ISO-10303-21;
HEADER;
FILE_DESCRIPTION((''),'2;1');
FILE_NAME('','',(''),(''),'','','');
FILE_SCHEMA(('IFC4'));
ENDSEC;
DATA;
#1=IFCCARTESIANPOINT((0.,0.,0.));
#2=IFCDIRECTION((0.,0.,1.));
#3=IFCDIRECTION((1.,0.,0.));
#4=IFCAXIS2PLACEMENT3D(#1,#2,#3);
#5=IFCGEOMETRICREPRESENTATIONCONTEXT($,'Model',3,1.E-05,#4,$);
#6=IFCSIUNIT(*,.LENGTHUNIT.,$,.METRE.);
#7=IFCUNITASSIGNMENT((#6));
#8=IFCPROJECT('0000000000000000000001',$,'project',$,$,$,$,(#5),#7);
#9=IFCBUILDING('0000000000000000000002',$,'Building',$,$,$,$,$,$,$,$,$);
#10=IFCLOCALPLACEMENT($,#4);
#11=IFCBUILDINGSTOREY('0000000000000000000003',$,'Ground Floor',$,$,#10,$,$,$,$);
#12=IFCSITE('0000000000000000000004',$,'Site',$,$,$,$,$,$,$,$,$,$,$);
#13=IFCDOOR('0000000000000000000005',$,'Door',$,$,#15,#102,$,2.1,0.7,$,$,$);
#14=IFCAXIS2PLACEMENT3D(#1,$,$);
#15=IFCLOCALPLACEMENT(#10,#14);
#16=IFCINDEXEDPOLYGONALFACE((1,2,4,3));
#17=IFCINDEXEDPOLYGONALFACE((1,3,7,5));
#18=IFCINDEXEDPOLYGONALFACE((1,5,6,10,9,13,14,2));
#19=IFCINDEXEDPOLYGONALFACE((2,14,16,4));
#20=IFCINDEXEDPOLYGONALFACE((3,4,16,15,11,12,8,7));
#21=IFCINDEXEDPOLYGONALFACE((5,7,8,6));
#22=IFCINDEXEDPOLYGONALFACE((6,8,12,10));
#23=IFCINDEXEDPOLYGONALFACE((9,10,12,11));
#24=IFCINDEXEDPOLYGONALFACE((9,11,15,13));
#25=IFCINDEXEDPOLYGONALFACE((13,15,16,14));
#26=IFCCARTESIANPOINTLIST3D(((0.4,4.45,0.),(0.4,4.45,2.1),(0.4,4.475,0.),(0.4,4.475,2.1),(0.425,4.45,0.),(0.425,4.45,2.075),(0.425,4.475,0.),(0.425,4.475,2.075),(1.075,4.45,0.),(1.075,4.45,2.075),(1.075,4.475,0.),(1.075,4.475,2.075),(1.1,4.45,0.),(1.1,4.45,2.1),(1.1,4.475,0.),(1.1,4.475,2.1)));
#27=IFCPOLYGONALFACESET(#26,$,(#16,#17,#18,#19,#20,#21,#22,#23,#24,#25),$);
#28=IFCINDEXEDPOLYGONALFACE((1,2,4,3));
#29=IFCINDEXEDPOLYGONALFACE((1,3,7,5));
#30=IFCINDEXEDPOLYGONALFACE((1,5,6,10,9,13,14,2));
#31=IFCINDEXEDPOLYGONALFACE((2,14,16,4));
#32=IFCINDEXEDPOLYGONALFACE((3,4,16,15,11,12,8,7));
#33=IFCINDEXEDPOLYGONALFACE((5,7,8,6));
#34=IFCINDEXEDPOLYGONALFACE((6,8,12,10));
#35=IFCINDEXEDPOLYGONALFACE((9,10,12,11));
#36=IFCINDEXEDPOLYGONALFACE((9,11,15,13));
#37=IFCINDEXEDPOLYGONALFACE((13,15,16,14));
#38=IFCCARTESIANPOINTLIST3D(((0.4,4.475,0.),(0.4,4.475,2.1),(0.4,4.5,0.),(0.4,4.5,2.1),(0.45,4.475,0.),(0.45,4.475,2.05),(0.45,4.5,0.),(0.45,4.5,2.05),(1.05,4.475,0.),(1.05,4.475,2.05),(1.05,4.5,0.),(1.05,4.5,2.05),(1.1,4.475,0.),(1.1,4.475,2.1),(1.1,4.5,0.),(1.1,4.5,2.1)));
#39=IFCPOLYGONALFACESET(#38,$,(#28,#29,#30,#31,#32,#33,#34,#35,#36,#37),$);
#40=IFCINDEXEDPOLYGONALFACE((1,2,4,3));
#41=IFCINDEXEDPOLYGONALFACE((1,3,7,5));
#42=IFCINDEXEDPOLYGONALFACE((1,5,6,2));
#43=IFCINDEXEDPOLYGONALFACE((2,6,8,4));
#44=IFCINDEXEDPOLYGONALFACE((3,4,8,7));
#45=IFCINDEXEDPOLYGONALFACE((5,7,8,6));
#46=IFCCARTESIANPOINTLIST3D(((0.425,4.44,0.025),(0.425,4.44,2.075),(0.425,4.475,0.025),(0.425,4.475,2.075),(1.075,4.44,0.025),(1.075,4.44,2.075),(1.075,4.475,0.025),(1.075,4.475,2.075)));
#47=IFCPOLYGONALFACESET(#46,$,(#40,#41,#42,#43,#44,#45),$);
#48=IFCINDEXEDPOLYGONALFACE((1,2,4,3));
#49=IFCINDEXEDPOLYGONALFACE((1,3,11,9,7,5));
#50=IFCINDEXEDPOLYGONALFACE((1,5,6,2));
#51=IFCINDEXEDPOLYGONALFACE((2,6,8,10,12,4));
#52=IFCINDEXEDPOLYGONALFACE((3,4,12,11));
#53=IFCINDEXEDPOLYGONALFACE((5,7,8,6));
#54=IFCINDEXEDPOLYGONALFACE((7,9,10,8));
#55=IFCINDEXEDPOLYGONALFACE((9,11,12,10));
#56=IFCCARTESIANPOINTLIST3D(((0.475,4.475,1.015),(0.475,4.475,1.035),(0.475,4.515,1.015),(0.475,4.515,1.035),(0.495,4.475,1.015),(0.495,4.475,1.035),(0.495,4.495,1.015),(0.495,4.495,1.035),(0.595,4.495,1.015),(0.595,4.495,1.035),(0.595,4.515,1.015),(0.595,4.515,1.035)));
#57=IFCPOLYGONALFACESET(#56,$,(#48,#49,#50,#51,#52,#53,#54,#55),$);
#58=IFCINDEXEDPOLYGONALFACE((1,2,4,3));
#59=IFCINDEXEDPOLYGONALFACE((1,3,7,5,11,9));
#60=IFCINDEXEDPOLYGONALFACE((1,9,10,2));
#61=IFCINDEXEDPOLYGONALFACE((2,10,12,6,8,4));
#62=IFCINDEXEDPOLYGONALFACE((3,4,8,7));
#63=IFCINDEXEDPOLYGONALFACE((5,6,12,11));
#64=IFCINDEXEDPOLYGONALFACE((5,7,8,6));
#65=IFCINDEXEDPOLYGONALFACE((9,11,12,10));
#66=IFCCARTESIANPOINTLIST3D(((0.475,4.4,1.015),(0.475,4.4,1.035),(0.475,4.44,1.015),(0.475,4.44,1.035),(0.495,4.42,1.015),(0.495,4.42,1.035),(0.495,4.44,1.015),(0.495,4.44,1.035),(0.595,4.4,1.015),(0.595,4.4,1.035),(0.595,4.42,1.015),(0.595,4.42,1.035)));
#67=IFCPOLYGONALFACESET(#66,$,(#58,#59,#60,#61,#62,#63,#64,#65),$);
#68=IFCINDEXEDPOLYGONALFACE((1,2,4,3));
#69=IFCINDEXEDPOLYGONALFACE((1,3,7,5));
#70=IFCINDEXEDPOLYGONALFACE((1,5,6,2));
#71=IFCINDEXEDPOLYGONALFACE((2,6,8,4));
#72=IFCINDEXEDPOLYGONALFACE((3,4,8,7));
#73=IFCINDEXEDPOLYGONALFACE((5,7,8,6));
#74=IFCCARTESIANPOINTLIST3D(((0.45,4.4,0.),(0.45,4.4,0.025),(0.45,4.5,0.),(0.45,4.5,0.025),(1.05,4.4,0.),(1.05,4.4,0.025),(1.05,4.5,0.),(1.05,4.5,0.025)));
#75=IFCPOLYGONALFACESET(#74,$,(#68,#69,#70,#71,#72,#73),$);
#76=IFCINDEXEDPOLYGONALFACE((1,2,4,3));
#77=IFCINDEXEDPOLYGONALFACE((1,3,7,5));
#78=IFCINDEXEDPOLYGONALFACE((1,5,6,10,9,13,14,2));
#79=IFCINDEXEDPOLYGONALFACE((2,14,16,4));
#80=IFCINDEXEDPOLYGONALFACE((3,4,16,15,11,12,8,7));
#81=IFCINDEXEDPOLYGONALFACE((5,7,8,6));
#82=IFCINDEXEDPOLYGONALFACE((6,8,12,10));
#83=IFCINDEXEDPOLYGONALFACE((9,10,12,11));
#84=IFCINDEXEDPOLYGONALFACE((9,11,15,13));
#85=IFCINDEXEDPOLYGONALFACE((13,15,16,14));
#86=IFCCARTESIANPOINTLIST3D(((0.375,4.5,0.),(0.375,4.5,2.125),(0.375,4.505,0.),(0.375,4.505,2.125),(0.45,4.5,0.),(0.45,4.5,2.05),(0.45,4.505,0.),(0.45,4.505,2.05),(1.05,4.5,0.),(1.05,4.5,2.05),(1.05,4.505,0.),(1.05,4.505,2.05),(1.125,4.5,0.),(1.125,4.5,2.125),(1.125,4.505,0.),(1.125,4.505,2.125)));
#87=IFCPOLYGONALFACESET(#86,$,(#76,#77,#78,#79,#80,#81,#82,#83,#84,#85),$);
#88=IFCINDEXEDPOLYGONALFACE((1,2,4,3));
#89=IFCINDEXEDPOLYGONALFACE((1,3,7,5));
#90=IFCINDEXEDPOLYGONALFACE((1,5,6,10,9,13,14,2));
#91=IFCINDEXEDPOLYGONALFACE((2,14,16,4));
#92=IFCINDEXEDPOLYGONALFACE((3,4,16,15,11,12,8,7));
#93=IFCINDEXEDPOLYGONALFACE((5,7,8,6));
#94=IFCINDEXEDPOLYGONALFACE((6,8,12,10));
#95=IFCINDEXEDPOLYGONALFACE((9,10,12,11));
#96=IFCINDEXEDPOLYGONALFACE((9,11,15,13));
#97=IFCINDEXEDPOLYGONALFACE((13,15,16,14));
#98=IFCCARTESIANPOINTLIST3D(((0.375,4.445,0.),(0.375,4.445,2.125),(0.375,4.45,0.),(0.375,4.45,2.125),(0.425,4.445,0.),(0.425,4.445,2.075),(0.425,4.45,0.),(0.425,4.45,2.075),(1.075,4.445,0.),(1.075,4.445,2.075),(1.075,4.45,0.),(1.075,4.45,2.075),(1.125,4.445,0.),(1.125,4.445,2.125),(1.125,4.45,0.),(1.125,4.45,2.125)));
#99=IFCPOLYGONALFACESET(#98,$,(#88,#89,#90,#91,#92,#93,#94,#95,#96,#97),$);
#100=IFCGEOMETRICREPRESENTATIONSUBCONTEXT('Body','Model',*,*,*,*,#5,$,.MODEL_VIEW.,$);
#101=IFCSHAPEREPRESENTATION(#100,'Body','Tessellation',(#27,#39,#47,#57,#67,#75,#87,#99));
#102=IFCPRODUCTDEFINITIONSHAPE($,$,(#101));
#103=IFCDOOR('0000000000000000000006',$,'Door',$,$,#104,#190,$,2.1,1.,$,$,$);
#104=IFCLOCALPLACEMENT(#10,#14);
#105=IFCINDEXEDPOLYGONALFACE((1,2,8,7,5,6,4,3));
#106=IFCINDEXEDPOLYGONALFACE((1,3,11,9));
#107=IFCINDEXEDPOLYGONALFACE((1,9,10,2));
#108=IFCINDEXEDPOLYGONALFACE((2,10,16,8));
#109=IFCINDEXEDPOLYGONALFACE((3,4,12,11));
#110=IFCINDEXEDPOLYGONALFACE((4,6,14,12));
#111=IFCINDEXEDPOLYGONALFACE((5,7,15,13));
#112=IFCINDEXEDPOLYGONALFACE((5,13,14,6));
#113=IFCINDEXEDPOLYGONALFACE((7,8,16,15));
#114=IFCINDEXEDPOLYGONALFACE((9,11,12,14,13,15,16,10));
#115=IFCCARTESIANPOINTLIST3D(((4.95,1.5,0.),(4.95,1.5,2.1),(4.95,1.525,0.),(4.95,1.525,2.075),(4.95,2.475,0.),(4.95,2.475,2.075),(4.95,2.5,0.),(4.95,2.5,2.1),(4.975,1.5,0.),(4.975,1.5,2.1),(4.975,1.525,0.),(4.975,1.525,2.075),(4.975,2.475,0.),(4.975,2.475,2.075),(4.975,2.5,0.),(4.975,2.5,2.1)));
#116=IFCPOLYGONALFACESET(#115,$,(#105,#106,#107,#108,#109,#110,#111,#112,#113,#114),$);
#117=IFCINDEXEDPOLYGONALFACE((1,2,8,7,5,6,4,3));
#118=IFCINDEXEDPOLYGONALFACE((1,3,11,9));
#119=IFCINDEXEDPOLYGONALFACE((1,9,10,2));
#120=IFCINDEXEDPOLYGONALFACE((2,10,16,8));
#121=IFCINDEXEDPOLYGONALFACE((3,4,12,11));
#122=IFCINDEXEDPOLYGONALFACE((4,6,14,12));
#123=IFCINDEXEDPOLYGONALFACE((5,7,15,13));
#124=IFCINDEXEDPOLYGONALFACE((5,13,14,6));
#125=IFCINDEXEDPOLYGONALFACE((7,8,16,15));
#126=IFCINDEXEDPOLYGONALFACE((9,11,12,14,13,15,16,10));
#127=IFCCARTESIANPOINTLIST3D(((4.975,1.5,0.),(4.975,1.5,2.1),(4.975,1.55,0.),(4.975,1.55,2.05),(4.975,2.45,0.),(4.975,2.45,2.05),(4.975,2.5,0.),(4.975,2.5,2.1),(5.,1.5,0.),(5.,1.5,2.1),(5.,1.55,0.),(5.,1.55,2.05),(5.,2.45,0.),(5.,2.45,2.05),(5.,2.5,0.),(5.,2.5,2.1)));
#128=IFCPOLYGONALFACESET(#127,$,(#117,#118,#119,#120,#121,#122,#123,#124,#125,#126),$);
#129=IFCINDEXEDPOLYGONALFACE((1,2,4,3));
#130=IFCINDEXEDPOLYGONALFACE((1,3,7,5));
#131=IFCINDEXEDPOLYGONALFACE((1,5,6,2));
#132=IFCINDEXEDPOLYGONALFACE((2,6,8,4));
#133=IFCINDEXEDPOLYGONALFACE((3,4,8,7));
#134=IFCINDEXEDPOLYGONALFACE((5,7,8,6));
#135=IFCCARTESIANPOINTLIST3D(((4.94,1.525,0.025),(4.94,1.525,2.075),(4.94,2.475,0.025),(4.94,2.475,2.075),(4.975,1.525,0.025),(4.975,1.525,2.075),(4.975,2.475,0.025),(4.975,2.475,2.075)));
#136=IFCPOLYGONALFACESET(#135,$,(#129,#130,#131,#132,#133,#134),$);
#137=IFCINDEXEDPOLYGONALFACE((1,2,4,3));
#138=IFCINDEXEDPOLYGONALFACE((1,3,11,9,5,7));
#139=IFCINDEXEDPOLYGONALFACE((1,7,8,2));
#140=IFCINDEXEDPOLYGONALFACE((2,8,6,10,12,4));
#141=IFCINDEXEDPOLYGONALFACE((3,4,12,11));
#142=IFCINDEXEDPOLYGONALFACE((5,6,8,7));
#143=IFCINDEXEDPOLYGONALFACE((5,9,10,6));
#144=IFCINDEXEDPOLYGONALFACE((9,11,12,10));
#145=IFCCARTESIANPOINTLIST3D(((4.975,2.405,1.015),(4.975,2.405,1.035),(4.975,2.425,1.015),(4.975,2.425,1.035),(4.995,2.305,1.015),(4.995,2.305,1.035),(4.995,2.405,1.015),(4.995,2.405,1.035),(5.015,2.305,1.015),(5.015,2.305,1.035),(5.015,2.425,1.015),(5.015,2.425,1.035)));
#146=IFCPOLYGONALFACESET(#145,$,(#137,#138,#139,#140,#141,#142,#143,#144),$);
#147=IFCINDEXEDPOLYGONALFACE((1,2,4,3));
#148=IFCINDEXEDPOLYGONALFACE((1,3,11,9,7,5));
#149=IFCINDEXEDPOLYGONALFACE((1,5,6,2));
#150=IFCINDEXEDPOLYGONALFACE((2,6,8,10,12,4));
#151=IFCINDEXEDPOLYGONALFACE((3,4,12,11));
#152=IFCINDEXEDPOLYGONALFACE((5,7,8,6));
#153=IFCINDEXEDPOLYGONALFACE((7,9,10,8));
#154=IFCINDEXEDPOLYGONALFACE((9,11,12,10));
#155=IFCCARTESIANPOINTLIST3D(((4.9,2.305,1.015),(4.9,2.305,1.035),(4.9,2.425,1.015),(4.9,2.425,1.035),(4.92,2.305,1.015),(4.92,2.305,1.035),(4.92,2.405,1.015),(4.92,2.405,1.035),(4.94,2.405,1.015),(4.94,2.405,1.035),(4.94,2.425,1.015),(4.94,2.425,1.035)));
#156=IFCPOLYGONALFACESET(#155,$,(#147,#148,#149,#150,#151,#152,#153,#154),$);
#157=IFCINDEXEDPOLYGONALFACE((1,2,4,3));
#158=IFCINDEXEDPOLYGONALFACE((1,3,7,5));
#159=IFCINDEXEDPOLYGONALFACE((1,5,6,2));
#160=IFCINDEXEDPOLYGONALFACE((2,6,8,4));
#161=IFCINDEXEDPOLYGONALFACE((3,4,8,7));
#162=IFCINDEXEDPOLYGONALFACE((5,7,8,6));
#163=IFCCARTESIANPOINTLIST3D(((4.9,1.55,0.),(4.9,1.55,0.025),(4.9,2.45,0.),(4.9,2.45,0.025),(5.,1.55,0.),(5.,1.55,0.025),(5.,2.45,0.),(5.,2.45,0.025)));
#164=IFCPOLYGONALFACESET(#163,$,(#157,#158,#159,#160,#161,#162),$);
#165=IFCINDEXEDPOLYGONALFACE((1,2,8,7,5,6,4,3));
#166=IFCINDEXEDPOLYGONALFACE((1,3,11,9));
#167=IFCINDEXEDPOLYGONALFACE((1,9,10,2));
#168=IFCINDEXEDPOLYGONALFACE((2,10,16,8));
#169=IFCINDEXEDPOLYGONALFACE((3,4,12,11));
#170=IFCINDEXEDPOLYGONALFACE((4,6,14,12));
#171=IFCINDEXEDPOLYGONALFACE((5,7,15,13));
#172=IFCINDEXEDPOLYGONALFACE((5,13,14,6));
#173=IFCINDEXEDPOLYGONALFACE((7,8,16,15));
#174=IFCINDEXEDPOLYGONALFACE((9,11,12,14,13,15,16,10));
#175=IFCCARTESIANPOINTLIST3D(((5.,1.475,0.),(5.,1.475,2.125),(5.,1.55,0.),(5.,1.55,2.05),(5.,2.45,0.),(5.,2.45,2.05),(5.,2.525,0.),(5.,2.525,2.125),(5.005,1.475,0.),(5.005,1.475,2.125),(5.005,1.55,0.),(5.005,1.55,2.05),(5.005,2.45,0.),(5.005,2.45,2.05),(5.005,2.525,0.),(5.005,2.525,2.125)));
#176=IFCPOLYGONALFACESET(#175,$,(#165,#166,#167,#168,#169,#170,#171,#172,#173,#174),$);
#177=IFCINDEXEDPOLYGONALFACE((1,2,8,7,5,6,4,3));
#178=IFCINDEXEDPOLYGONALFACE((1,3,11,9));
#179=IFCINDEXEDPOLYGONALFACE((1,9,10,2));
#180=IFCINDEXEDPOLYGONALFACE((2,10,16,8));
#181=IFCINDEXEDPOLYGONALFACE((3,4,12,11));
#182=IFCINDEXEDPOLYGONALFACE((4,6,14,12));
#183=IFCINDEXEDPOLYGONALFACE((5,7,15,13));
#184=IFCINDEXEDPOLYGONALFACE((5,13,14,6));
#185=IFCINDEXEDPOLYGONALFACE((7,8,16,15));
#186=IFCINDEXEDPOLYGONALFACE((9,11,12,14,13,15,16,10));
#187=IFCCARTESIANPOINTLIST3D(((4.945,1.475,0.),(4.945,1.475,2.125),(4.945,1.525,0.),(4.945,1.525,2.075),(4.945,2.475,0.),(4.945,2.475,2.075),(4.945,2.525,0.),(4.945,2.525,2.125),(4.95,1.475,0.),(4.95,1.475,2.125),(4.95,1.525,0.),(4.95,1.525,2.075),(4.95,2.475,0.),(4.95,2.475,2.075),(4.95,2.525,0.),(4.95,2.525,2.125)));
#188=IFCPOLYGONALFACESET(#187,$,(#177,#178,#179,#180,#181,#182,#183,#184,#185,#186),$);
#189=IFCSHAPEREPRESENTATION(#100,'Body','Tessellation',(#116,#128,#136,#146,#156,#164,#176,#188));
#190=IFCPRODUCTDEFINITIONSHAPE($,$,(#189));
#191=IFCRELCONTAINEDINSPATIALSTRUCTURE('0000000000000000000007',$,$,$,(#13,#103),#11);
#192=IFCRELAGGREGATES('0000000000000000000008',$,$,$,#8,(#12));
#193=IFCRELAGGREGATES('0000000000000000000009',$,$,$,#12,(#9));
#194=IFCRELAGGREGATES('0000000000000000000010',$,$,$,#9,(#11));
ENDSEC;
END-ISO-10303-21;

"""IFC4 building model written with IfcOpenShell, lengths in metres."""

from ifc_helpers import new_model, si_unit, frame, origin_with_axes, place, context, subcontext, project, spatial, line, indexed_curve, outline, extrude, element, save


model = new_model("IFC4")

# Units and contexts
model_context = context("Model", 3, precision=1e-05, world=origin_with_axes())
body_context = subcontext(model_context, "Body", "Model", "MODEL_VIEW")
ifc_project = project(units=[si_unit("LENGTHUNIT", "METRE")], contexts=[model_context])

# Site, building, storey
site = spatial("IfcSite", under=ifc_project, Name="Site")
building = spatial("IfcBuilding", under=site, Name="Building")
storey_placement = place(None, origin_with_axes())
storey = spatial("IfcBuildingStorey", under=building, at=storey_placement, Name="Ground Floor")

# Doors
door_1_placement = place(storey_placement, frame((1.1, 4.5, 0.0), z_axis=(0.0, 0.0, 1.0), x_axis=(-1.0, 0.0, 0.0)))
element("IfcDoor", 1, at=door_1_placement, inside=storey, Name="Door", OverallHeight=2.1, OverallWidth=0.7, context=body_context, shape_type="SweptSolid", body=[
    extrude(outline(indexed_curve([(0.0, 0.0), (0.0, 2.1), (0.7, 2.1), (0.7, 0.0), (0.675, 0.0), (0.675, 2.075), (0.025, 2.075), (0.025, 0.0)], segments=[line(1, 2, 3, 4, 5, 6, 7, 8, 1)])), frame((0.0, 0.025, 0.0), z_axis=(0.0, -1.0, 0.0), x_axis=(1.0, 0.0, 0.0)), (0.0, 0.0, -1.0), 0.025),
    extrude(outline(indexed_curve([(0.0, 0.0), (0.0, 2.1), (0.7, 2.1), (0.7, 0.0), (0.65, 0.0), (0.65, 2.05), (0.05, 2.05), (0.05, 0.0)], segments=[line(1, 2, 3, 4, 5, 6, 7, 8, 1)])), frame((0.0, 0.0, 0.0), z_axis=(0.0, -1.0, 0.0), x_axis=(1.0, 0.0, 0.0)), (0.0, 0.0, -1.0), 0.025),
    extrude(outline(indexed_curve([(0.0, 0.0), (0.65, 0.0), (0.65, 0.035), (0.0, 0.035)], segments=[line(1, 2, 3, 4, 1)])), frame((0.025, 0.025, 0.025), z_axis=(0.0, 0.0, 1.0), x_axis=(1.0, 0.0, 0.0)), (0.0, 0.0, 1.0), 2.05),
    extrude(outline(indexed_curve([(0.0, 0.0), (0.0, -0.04), (-0.12, -0.04), (-0.12, -0.02), (-0.02, -0.02), (-0.02, 0.0)], segments=[line(1, 2, 3, 4, 5, 6, 1)])), frame((0.625, 0.025, 1.015), z_axis=(0.0, 0.0, 1.0), x_axis=(1.0, 0.0, 0.0)), (0.0, 0.0, 1.0), 0.02),
    extrude(outline(indexed_curve([(0.0, 0.0), (0.0, 0.04), (-0.12, 0.04), (-0.12, 0.02), (-0.02, 0.02), (-0.02, 0.0)], segments=[line(1, 2, 3, 4, 5, 6, 1)])), frame((0.625, 0.06, 1.015), z_axis=(0.0, 0.0, 1.0), x_axis=(1.0, 0.0, 0.0)), (0.0, 0.0, 1.0), 0.02),
    extrude(outline(indexed_curve([(0.0, 0.0), (0.6, 0.0), (0.6, 0.1), (0.0, 0.1)], segments=[line(1, 2, 3, 4, 1)])), frame((0.05, 0.0, 0.0), z_axis=(0.0, 0.0, 1.0), x_axis=(1.0, 0.0, 0.0)), (0.0, 0.0, 1.0), 0.025),
    extrude(outline(indexed_curve([(0.0, 0.0), (0.0, 2.125), (0.75, 2.125), (0.75, 0.0), (0.675, 0.0), (0.675, 2.05), (0.075, 2.05), (0.075, 0.0)], segments=[line(1, 2, 3, 4, 5, 6, 7, 8, 1)])), frame((-0.025, -0.005, 0.0), z_axis=(0.0, -1.0, 0.0), x_axis=(1.0, 0.0, 0.0)), (0.0, 0.0, -1.0), 0.005),
    extrude(outline(indexed_curve([(0.0, 0.0), (0.0, 2.125), (0.75, 2.125), (0.75, 0.0), (0.7, 0.0), (0.7, 2.075), (0.05, 2.075), (0.05, 0.0)], segments=[line(1, 2, 3, 4, 5, 6, 7, 8, 1)])), frame((-0.025, 0.05, 0.0), z_axis=(0.0, -1.0, 0.0), x_axis=(1.0, 0.0, 0.0)), (0.0, 0.0, -1.0), 0.005),
])
door_2_placement = place(storey_placement, frame((5.0, 1.5, 0.0), z_axis=(0.0, 0.0, 1.0), x_axis=(0.0, 1.0, 0.0)))
element("IfcDoor", 2, at=door_2_placement, inside=storey, Name="Door", OverallHeight=2.1, OverallWidth=1.0, context=body_context, shape_type="SweptSolid", body=[
    extrude(outline(indexed_curve([(0.0, 0.0), (0.0, 2.1), (1.0, 2.1), (1.0, 0.0), (0.975, 0.0), (0.975, 2.075), (0.025, 2.075), (0.025, 0.0)], segments=[line(1, 2, 3, 4, 5, 6, 7, 8, 1)])), frame((0.0, 0.025, 0.0), z_axis=(0.0, -1.0, 0.0), x_axis=(1.0, 0.0, 0.0)), (0.0, 0.0, -1.0), 0.025),
    extrude(outline(indexed_curve([(0.0, 0.0), (0.0, 2.1), (1.0, 2.1), (1.0, 0.0), (0.95, 0.0), (0.95, 2.05), (0.05, 2.05), (0.05, 0.0)], segments=[line(1, 2, 3, 4, 5, 6, 7, 8, 1)])), frame((0.0, 0.0, 0.0), z_axis=(0.0, -1.0, 0.0), x_axis=(1.0, 0.0, 0.0)), (0.0, 0.0, -1.0), 0.025),
    extrude(outline(indexed_curve([(0.0, 0.0), (0.95, 0.0), (0.95, 0.035), (0.0, 0.035)], segments=[line(1, 2, 3, 4, 1)])), frame((0.025, 0.025, 0.025), z_axis=(0.0, 0.0, 1.0), x_axis=(1.0, 0.0, 0.0)), (0.0, 0.0, 1.0), 2.05),
    extrude(outline(indexed_curve([(0.0, 0.0), (0.0, -0.04), (-0.12, -0.04), (-0.12, -0.02), (-0.02, -0.02), (-0.02, 0.0)], segments=[line(1, 2, 3, 4, 5, 6, 1)])), frame((0.925, 0.025, 1.015), z_axis=(0.0, 0.0, 1.0), x_axis=(1.0, 0.0, 0.0)), (0.0, 0.0, 1.0), 0.02),
    extrude(outline(indexed_curve([(0.0, 0.0), (0.0, 0.04), (-0.12, 0.04), (-0.12, 0.02), (-0.02, 0.02), (-0.02, 0.0)], segments=[line(1, 2, 3, 4, 5, 6, 1)])), frame((0.925, 0.06, 1.015), z_axis=(0.0, 0.0, 1.0), x_axis=(1.0, 0.0, 0.0)), (0.0, 0.0, 1.0), 0.02),
    extrude(outline(indexed_curve([(0.0, 0.0), (0.9, 0.0), (0.9, 0.1), (0.0, 0.1)], segments=[line(1, 2, 3, 4, 1)])), frame((0.05, 0.0, 0.0), z_axis=(0.0, 0.0, 1.0), x_axis=(1.0, 0.0, 0.0)), (0.0, 0.0, 1.0), 0.025),
    extrude(outline(indexed_curve([(0.0, 0.0), (0.0, 2.125), (1.05, 2.125), (1.05, 0.0), (0.975, 0.0), (0.975, 2.05), (0.075, 2.05), (0.075, 0.0)], segments=[line(1, 2, 3, 4, 5, 6, 7, 8, 1)])), frame((-0.025, -0.005, 0.0), z_axis=(0.0, -1.0, 0.0), x_axis=(1.0, 0.0, 0.0)), (0.0, 0.0, -1.0), 0.005),
    extrude(outline(indexed_curve([(0.0, 0.0), (0.0, 2.125), (1.05, 2.125), (1.05, 0.0), (1.0, 0.0), (1.0, 2.075), (0.05, 2.075), (0.05, 0.0)], segments=[line(1, 2, 3, 4, 5, 6, 7, 8, 1)])), frame((-0.025, 0.05, 0.0), z_axis=(0.0, -1.0, 0.0), x_axis=(1.0, 0.0, 0.0)), (0.0, 0.0, -1.0), 0.005),
])

save(model, "model.ifc")
